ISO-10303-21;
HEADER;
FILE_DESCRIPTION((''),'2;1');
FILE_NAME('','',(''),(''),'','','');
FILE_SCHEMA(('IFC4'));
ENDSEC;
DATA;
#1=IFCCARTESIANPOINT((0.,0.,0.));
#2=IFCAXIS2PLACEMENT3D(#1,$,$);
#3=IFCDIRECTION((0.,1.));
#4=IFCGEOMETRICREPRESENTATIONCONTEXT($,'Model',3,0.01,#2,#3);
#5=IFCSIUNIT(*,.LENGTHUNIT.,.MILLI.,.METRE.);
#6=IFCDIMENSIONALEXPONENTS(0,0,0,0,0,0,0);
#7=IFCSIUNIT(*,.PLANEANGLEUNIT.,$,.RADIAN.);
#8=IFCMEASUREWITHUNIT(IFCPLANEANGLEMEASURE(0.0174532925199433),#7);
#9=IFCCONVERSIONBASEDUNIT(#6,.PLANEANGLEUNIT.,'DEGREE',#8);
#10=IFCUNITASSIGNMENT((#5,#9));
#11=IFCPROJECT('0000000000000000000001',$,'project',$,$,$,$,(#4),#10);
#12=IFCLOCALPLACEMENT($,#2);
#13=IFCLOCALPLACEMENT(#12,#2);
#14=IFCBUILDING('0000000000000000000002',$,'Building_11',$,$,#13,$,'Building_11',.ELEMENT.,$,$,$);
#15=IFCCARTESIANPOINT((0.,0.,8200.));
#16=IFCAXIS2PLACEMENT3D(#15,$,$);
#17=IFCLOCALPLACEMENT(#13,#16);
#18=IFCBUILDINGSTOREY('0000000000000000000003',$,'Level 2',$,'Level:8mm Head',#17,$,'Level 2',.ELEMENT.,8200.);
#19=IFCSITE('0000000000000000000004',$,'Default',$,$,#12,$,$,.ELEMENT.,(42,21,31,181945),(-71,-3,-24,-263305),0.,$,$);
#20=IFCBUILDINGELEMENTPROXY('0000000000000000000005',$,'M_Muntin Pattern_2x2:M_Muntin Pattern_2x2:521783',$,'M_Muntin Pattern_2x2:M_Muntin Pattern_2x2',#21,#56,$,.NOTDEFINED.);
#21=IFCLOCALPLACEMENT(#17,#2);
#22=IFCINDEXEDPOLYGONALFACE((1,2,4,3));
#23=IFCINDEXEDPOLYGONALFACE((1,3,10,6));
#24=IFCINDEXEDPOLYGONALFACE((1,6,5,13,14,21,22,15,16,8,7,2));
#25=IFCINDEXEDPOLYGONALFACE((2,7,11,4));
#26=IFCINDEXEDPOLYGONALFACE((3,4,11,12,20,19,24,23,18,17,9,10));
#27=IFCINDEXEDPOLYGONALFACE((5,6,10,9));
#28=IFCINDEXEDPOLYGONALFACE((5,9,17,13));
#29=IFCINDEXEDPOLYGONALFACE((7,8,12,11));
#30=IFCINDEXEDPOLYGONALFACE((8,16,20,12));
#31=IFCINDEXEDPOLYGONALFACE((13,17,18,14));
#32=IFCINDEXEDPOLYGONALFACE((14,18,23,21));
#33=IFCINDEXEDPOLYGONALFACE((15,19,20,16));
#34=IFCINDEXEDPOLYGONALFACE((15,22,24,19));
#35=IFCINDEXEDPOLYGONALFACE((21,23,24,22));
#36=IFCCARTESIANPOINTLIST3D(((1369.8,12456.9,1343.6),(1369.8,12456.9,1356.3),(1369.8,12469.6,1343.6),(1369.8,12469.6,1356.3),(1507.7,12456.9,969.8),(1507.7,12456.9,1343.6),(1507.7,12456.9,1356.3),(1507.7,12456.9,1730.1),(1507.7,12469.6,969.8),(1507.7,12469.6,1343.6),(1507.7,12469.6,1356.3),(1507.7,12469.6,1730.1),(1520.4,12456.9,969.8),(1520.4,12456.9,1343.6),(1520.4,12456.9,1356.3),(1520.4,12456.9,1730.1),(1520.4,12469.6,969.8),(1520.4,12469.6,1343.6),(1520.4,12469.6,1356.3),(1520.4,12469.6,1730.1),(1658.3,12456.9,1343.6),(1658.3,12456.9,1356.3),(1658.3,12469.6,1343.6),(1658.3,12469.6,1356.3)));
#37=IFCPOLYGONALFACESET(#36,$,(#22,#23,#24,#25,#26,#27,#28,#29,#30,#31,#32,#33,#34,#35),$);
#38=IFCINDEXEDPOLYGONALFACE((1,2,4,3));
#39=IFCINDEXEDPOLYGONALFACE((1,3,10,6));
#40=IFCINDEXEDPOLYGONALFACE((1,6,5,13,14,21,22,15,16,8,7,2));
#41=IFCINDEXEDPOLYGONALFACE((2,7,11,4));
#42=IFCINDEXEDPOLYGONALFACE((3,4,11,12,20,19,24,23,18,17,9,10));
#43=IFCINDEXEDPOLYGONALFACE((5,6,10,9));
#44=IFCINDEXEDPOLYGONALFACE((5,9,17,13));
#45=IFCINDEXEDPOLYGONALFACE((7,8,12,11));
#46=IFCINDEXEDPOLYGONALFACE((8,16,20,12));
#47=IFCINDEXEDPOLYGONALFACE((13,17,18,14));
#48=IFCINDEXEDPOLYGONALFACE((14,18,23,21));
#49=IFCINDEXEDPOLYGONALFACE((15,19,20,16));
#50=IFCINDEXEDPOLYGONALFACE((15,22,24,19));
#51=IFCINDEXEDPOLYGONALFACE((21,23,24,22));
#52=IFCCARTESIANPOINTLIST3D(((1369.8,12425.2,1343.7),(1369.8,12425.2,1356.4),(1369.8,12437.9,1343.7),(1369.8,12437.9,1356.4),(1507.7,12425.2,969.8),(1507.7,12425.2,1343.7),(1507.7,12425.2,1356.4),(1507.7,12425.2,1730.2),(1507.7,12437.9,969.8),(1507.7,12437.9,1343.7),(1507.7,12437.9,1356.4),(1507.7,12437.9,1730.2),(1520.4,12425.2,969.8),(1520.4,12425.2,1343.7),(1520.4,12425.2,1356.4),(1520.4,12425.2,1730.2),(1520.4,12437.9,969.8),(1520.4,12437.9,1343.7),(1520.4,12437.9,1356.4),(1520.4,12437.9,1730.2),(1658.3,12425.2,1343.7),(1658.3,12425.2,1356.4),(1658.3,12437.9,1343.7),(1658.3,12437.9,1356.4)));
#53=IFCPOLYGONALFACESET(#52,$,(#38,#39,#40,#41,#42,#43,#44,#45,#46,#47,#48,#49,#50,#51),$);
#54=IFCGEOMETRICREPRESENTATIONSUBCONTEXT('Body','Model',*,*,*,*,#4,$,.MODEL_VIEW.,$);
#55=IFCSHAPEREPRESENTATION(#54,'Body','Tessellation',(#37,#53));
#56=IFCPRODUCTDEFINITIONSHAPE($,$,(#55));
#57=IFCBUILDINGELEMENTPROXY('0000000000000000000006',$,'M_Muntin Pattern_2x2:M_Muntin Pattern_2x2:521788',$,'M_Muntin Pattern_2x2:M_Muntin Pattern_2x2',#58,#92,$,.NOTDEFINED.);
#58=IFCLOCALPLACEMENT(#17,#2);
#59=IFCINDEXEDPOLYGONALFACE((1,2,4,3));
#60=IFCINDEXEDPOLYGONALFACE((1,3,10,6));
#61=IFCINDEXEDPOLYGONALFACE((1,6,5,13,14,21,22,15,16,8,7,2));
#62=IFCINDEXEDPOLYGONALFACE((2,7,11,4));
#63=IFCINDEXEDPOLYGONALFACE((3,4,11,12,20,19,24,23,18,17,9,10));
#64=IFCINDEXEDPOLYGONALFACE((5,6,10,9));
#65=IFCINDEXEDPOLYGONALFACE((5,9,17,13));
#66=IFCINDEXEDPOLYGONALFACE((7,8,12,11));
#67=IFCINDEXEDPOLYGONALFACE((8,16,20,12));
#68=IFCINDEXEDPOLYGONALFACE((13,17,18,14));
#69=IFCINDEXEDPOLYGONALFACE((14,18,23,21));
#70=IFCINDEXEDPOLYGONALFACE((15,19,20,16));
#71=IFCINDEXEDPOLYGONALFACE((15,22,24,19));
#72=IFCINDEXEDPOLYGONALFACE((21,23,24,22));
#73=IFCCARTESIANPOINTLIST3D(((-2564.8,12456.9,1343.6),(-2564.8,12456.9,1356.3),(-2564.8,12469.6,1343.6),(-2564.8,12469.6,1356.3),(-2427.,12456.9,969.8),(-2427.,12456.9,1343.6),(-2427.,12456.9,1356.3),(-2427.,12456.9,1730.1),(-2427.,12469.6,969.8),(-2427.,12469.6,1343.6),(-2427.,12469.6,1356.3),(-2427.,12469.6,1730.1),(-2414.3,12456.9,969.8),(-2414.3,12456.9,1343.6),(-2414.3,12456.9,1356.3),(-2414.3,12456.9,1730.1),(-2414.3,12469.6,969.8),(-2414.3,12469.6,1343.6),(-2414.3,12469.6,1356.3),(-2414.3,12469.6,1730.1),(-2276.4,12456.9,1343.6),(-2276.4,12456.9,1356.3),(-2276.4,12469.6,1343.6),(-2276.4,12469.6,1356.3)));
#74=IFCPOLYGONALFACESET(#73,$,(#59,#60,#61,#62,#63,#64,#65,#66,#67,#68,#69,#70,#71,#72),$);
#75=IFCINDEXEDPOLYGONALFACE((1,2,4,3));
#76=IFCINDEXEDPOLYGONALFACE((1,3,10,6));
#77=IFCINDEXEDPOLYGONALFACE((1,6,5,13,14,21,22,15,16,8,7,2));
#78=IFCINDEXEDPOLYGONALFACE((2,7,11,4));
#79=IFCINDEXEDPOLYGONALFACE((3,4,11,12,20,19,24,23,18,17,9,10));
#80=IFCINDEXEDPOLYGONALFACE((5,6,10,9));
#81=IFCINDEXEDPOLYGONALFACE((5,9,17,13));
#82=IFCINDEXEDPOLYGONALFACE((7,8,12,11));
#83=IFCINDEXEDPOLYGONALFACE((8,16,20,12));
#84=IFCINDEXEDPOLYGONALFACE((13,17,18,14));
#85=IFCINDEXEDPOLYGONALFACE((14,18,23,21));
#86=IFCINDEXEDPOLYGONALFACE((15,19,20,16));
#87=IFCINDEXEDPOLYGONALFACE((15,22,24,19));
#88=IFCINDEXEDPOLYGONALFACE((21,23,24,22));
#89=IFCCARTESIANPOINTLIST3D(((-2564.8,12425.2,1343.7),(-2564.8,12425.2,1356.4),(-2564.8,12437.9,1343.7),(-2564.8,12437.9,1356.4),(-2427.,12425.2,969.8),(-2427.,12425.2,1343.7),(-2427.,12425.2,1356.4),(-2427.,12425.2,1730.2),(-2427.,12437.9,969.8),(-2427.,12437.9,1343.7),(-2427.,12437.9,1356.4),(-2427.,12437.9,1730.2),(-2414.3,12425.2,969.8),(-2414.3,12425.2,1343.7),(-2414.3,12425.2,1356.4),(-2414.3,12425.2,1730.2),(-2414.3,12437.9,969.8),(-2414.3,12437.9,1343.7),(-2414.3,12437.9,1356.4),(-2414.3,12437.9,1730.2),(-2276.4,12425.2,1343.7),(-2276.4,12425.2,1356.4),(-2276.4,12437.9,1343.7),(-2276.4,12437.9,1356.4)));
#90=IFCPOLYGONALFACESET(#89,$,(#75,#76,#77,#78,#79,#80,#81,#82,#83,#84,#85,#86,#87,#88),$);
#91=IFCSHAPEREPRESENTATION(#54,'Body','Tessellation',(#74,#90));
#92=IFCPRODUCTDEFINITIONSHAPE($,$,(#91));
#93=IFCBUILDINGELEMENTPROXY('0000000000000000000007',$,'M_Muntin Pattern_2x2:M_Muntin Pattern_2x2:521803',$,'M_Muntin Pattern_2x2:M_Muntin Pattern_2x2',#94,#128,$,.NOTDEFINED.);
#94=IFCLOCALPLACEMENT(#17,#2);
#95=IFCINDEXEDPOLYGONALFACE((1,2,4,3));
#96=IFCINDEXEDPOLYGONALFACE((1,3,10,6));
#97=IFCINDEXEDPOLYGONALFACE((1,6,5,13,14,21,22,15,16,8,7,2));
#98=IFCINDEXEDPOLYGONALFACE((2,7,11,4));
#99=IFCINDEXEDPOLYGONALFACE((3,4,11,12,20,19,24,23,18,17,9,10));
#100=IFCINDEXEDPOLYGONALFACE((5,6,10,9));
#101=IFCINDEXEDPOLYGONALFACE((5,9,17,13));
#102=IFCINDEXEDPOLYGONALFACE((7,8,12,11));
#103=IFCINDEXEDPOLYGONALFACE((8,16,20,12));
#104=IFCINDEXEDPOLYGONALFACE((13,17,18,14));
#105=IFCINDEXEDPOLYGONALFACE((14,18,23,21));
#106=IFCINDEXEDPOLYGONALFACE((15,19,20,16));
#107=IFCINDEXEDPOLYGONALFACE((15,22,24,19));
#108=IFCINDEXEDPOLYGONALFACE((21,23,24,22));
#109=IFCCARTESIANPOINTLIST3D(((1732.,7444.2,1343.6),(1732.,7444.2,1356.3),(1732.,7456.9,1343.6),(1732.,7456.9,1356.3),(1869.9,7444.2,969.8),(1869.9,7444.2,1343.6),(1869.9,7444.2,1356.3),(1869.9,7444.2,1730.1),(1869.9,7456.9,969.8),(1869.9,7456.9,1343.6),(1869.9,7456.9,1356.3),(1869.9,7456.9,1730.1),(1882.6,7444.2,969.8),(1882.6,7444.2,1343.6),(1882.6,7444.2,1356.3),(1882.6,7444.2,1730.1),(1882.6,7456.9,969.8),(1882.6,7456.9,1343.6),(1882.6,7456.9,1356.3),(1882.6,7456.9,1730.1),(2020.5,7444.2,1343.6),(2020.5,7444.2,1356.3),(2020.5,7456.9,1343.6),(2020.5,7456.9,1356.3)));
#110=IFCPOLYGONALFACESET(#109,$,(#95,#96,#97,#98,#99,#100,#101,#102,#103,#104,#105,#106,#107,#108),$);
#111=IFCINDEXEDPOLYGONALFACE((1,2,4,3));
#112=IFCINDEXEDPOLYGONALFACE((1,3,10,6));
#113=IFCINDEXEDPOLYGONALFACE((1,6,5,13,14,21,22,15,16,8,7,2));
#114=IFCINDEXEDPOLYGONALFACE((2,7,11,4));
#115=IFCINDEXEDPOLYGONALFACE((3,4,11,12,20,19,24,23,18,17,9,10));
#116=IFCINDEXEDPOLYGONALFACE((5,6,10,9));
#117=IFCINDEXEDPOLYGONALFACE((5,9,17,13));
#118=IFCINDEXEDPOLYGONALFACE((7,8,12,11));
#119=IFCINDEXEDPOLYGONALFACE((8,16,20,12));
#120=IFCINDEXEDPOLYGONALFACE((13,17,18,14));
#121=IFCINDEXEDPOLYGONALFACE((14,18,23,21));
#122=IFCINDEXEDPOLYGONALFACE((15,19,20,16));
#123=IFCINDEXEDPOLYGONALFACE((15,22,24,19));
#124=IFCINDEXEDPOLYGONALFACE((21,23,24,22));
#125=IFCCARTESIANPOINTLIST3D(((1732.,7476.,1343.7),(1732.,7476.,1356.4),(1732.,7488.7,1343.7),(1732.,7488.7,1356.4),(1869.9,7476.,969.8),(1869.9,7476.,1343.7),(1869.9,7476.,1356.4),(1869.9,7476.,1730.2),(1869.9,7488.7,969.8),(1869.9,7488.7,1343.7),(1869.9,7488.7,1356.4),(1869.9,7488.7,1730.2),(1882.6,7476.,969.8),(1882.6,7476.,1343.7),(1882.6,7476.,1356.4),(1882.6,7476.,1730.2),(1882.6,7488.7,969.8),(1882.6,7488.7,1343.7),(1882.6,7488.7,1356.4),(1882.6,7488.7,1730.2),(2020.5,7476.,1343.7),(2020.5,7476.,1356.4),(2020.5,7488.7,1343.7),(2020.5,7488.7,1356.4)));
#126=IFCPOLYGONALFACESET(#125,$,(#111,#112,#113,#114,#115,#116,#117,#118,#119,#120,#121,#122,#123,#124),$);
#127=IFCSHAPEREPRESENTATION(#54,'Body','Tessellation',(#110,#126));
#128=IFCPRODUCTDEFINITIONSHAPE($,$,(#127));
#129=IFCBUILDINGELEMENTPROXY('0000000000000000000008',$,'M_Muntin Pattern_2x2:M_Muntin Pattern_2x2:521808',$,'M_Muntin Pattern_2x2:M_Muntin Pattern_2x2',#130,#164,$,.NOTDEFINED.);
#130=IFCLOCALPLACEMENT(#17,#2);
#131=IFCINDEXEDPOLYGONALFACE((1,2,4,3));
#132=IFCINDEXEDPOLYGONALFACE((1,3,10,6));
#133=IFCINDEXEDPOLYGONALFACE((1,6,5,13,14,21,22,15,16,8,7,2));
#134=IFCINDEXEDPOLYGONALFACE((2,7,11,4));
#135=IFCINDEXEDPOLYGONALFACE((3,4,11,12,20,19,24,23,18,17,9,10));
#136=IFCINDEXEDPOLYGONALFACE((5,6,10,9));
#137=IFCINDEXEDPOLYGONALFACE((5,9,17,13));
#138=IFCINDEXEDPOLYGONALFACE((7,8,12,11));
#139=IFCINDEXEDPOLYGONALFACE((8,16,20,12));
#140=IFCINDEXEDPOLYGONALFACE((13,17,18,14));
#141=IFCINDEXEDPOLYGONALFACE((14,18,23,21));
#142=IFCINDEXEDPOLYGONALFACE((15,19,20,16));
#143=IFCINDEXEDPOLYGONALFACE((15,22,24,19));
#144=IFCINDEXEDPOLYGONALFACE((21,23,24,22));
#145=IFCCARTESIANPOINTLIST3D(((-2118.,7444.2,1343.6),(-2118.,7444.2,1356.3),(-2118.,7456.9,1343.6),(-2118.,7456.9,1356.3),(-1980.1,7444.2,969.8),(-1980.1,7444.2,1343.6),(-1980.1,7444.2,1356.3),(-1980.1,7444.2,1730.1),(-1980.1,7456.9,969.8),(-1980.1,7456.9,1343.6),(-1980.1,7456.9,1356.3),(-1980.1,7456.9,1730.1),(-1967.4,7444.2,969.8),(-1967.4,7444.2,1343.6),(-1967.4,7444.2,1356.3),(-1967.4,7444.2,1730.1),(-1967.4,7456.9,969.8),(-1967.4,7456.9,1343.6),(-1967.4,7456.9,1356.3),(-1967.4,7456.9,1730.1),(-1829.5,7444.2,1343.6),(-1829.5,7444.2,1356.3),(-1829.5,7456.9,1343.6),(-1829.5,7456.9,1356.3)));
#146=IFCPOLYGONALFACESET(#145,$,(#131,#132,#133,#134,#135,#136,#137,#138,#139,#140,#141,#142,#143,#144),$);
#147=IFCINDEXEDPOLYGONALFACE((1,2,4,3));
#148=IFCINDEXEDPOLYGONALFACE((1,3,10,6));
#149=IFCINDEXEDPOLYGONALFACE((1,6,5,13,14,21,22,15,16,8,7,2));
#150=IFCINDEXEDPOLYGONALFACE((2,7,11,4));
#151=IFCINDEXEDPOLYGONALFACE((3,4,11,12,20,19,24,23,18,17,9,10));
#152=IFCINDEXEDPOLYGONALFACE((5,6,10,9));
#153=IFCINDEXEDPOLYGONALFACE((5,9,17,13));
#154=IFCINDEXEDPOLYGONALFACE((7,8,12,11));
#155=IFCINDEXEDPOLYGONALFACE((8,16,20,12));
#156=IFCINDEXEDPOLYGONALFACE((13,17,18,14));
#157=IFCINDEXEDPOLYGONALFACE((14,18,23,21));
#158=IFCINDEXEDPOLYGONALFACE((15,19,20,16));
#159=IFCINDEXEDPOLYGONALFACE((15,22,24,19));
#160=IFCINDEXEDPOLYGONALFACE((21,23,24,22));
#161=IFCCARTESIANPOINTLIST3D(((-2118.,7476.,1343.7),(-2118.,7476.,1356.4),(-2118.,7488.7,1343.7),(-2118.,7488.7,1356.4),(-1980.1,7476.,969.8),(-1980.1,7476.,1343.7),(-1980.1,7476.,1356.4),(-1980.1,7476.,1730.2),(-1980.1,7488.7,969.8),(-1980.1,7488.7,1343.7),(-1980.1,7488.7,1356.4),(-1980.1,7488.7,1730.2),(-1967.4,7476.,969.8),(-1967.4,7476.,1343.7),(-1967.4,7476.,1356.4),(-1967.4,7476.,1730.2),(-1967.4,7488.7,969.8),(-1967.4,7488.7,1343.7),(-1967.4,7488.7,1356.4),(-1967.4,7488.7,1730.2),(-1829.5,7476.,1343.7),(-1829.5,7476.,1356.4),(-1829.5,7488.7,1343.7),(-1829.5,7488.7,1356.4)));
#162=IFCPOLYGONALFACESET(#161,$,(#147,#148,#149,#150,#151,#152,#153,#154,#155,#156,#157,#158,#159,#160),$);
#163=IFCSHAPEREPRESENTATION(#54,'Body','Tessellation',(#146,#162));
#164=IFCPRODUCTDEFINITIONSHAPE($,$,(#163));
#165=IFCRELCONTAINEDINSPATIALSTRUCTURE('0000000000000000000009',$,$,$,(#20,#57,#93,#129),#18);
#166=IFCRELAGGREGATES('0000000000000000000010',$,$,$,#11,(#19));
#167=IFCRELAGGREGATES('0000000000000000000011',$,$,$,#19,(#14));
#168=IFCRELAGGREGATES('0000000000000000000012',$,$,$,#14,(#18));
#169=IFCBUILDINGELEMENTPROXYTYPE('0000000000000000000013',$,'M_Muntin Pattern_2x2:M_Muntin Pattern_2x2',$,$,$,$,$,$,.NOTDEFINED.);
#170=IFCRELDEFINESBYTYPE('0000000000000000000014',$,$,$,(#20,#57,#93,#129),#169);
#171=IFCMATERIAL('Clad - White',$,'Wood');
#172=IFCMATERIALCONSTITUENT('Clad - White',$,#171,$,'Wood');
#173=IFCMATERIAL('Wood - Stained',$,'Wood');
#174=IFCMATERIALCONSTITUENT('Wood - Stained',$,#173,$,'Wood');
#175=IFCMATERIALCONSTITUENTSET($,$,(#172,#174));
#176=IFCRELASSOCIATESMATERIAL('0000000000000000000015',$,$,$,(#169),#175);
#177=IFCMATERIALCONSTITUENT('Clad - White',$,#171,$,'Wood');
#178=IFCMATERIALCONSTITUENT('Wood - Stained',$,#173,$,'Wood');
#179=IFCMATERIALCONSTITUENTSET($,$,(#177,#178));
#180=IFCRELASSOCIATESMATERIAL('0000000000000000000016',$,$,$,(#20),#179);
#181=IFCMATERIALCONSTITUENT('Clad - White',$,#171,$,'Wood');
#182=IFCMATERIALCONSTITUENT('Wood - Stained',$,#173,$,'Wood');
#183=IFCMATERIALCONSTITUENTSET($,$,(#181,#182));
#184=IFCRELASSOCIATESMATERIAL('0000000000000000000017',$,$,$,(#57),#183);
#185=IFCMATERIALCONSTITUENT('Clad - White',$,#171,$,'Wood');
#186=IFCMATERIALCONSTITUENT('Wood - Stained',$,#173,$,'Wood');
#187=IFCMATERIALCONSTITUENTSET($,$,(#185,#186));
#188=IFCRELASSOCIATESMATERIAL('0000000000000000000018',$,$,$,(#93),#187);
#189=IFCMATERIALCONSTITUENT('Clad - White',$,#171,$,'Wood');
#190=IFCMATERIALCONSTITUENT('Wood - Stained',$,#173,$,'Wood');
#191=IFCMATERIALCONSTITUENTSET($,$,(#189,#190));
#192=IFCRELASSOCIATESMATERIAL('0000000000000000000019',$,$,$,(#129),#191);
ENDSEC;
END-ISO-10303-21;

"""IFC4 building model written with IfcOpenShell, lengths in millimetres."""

from ifc_helpers import new_model, entity, si_unit, converted_unit, direction, frame, origin, place, context, subcontext, project, spatial, indexed_curve, outline, extrude, source, transform, mapped, material, constituent, constituent_set, type_object, type_shapes, element, save


model = new_model("IFC4")

# Units and contexts
model_context = context("Model", 3, precision=0.01, world=origin(), true_north=direction((0.0, 1.0)))
body_context = subcontext(model_context, "Body", "Model", "MODEL_VIEW")
ifc_project = project(units=[si_unit("LENGTHUNIT", "METRE", prefix="MILLI"), converted_unit("PLANEANGLEUNIT", "DEGREE", entity("IfcPlaneAngleMeasure", 0.0174532925199433), si_unit("PLANEANGLEUNIT", "RADIAN"), dimensions=[0, 0, 0, 0, 0, 0, 0])], contexts=[model_context])

# Site, building, storey
site_placement = place(None, origin())
site = spatial("IfcSite", under=ifc_project, at=site_placement, Name="Default", CompositionType="ELEMENT", RefLatitude=(42, 21, 31, 181945), RefLongitude=(-71, -3, -24, -263305), RefElevation=0.0)
building_placement = place(site_placement, origin())
building = spatial("IfcBuilding", under=site, at=building_placement, Name="Building_11", LongName="Building_11", CompositionType="ELEMENT")
storey_placement = place(building_placement, frame((0.0, 0.0, 8200.0)))
storey = spatial("IfcBuildingStorey", under=building, at=storey_placement, Name="Level 2", ObjectType="Level:8mm Head", LongName="Level 2", CompositionType="ELEMENT", Elevation=8200.0)

# Building element proxies
ifc_material_1 = material(Name="Clad - White", Category="Wood")
ifc_constituent_1 = constituent(ifc_material_1, Name="Clad - White", Category="Wood")
ifc_material_2 = material(Name="Wood - Stained", Category="Wood")
ifc_constituent_2 = constituent(ifc_material_2, Name="Wood - Stained", Category="Wood")
ifc_constituent_set_1 = constituent_set(constituents=[ifc_constituent_1, ifc_constituent_2])
ifc_constituent_3 = constituent(ifc_material_1, Name="Clad - White", Category="Wood")
ifc_constituent_4 = constituent(ifc_material_2, Name="Wood - Stained", Category="Wood")
ifc_constituent_set_2 = constituent_set(constituents=[ifc_constituent_3, ifc_constituent_4])
building_element_proxy_type_1 = type_object("IfcBuildingElementProxyType", Name="M_Muntin Pattern_2x2:M_Muntin Pattern_2x2", PredefinedType="NOTDEFINED", material=ifc_constituent_set_2)
shared_shape_1 = source(origin(), body_context, "Body", "SweptSolid", [
    extrude(outline(indexed_curve([(6.4, -6.4), (380.1, -6.4), (380.1, 6.3), (6.4, 6.3), (6.4, 144.2), (-6.3, 144.2), (-6.3, 6.3), (-380.2, 6.3), (-380.2, -6.4), (-6.3, -6.4), (-6.3, -144.2), (6.4, -144.2), (6.4, -6.4)], self_intersect=False)), frame((0.0, 9.5, 380.1), z_axis=(0.0, 1.0, 0.0), x_axis=(0.0, 0.0, 1.0)), (0.0, 0.0, 1.0), 12.7),
    extrude(outline(indexed_curve([(6.4, -6.4), (380.2, -6.4), (380.2, 6.3), (6.4, 6.3), (6.4, 144.2), (-6.3, 144.2), (-6.3, 6.3), (-380.2, 6.3), (-380.2, -6.4), (-6.3, -6.4), (-6.3, -144.2), (6.4, -144.2), (6.4, -6.4)], self_intersect=False)), frame((0.0, -22.2, 380.2), z_axis=(0.0, 1.0, 0.0), x_axis=(0.0, 0.0, 1.0)), (0.0, 0.0, 1.0), 12.7),
])
type_shapes(building_element_proxy_type_1, [shared_shape_1])
proxy_1_placement = place(storey_placement, frame((1514.0, 12447.4, 969.8)))
element("IfcBuildingElementProxy", 1, at=proxy_1_placement, inside=storey, type_object=building_element_proxy_type_1, material=ifc_constituent_set_1, Name="M_Muntin Pattern_2x2:M_Muntin Pattern_2x2:521783", ObjectType="M_Muntin Pattern_2x2:M_Muntin Pattern_2x2", PredefinedType="NOTDEFINED", context=body_context, shape_type="MappedRepresentation", body=[
    mapped(shared_shape_1, transform((0.0, 0.0, 0.0), scale=1.0)),
])
ifc_constituent_5 = constituent(ifc_material_1, Name="Clad - White", Category="Wood")
ifc_constituent_6 = constituent(ifc_material_2, Name="Wood - Stained", Category="Wood")
ifc_constituent_set_3 = constituent_set(constituents=[ifc_constituent_5, ifc_constituent_6])
proxy_2_placement = place(storey_placement, frame((-2420.6, 12447.4, 969.8)))
element("IfcBuildingElementProxy", 2, at=proxy_2_placement, inside=storey, type_object=building_element_proxy_type_1, material=ifc_constituent_set_3, Name="M_Muntin Pattern_2x2:M_Muntin Pattern_2x2:521788", ObjectType="M_Muntin Pattern_2x2:M_Muntin Pattern_2x2", PredefinedType="NOTDEFINED", context=body_context, shape_type="MappedRepresentation", body=[
    mapped(shared_shape_1, transform((0.0, 0.0, 0.0), scale=1.0)),
])
ifc_constituent_7 = constituent(ifc_material_1, Name="Clad - White", Category="Wood")
ifc_constituent_8 = constituent(ifc_material_2, Name="Wood - Stained", Category="Wood")
ifc_constituent_set_4 = constituent_set(constituents=[ifc_constituent_7, ifc_constituent_8])
proxy_3_placement = place(storey_placement, frame((1876.2, 7466.4, 969.8), z_axis=(0.0, 0.0, 1.0), x_axis=(-1.0, 0.0, 0.0)))
element("IfcBuildingElementProxy", 3, at=proxy_3_placement, inside=storey, type_object=building_element_proxy_type_1, material=ifc_constituent_set_4, Name="M_Muntin Pattern_2x2:M_Muntin Pattern_2x2:521803", ObjectType="M_Muntin Pattern_2x2:M_Muntin Pattern_2x2", PredefinedType="NOTDEFINED", context=body_context, shape_type="MappedRepresentation", body=[
    mapped(shared_shape_1, transform((0.0, 0.0, 0.0), scale=1.0)),
])
ifc_constituent_9 = constituent(ifc_material_1, Name="Clad - White", Category="Wood")
ifc_constituent_10 = constituent(ifc_material_2, Name="Wood - Stained", Category="Wood")
ifc_constituent_set_5 = constituent_set(constituents=[ifc_constituent_9, ifc_constituent_10])
proxy_4_placement = place(storey_placement, frame((-1973.8, 7466.4, 969.8), z_axis=(0.0, 0.0, 1.0), x_axis=(-1.0, 0.0, 0.0)))
element("IfcBuildingElementProxy", 4, at=proxy_4_placement, inside=storey, type_object=building_element_proxy_type_1, material=ifc_constituent_set_5, Name="M_Muntin Pattern_2x2:M_Muntin Pattern_2x2:521808", ObjectType="M_Muntin Pattern_2x2:M_Muntin Pattern_2x2", PredefinedType="NOTDEFINED", context=body_context, shape_type="MappedRepresentation", body=[
    mapped(shared_shape_1, transform((0.0, 0.0, 0.0), scale=1.0)),
])

save(model, "model.ifc")
